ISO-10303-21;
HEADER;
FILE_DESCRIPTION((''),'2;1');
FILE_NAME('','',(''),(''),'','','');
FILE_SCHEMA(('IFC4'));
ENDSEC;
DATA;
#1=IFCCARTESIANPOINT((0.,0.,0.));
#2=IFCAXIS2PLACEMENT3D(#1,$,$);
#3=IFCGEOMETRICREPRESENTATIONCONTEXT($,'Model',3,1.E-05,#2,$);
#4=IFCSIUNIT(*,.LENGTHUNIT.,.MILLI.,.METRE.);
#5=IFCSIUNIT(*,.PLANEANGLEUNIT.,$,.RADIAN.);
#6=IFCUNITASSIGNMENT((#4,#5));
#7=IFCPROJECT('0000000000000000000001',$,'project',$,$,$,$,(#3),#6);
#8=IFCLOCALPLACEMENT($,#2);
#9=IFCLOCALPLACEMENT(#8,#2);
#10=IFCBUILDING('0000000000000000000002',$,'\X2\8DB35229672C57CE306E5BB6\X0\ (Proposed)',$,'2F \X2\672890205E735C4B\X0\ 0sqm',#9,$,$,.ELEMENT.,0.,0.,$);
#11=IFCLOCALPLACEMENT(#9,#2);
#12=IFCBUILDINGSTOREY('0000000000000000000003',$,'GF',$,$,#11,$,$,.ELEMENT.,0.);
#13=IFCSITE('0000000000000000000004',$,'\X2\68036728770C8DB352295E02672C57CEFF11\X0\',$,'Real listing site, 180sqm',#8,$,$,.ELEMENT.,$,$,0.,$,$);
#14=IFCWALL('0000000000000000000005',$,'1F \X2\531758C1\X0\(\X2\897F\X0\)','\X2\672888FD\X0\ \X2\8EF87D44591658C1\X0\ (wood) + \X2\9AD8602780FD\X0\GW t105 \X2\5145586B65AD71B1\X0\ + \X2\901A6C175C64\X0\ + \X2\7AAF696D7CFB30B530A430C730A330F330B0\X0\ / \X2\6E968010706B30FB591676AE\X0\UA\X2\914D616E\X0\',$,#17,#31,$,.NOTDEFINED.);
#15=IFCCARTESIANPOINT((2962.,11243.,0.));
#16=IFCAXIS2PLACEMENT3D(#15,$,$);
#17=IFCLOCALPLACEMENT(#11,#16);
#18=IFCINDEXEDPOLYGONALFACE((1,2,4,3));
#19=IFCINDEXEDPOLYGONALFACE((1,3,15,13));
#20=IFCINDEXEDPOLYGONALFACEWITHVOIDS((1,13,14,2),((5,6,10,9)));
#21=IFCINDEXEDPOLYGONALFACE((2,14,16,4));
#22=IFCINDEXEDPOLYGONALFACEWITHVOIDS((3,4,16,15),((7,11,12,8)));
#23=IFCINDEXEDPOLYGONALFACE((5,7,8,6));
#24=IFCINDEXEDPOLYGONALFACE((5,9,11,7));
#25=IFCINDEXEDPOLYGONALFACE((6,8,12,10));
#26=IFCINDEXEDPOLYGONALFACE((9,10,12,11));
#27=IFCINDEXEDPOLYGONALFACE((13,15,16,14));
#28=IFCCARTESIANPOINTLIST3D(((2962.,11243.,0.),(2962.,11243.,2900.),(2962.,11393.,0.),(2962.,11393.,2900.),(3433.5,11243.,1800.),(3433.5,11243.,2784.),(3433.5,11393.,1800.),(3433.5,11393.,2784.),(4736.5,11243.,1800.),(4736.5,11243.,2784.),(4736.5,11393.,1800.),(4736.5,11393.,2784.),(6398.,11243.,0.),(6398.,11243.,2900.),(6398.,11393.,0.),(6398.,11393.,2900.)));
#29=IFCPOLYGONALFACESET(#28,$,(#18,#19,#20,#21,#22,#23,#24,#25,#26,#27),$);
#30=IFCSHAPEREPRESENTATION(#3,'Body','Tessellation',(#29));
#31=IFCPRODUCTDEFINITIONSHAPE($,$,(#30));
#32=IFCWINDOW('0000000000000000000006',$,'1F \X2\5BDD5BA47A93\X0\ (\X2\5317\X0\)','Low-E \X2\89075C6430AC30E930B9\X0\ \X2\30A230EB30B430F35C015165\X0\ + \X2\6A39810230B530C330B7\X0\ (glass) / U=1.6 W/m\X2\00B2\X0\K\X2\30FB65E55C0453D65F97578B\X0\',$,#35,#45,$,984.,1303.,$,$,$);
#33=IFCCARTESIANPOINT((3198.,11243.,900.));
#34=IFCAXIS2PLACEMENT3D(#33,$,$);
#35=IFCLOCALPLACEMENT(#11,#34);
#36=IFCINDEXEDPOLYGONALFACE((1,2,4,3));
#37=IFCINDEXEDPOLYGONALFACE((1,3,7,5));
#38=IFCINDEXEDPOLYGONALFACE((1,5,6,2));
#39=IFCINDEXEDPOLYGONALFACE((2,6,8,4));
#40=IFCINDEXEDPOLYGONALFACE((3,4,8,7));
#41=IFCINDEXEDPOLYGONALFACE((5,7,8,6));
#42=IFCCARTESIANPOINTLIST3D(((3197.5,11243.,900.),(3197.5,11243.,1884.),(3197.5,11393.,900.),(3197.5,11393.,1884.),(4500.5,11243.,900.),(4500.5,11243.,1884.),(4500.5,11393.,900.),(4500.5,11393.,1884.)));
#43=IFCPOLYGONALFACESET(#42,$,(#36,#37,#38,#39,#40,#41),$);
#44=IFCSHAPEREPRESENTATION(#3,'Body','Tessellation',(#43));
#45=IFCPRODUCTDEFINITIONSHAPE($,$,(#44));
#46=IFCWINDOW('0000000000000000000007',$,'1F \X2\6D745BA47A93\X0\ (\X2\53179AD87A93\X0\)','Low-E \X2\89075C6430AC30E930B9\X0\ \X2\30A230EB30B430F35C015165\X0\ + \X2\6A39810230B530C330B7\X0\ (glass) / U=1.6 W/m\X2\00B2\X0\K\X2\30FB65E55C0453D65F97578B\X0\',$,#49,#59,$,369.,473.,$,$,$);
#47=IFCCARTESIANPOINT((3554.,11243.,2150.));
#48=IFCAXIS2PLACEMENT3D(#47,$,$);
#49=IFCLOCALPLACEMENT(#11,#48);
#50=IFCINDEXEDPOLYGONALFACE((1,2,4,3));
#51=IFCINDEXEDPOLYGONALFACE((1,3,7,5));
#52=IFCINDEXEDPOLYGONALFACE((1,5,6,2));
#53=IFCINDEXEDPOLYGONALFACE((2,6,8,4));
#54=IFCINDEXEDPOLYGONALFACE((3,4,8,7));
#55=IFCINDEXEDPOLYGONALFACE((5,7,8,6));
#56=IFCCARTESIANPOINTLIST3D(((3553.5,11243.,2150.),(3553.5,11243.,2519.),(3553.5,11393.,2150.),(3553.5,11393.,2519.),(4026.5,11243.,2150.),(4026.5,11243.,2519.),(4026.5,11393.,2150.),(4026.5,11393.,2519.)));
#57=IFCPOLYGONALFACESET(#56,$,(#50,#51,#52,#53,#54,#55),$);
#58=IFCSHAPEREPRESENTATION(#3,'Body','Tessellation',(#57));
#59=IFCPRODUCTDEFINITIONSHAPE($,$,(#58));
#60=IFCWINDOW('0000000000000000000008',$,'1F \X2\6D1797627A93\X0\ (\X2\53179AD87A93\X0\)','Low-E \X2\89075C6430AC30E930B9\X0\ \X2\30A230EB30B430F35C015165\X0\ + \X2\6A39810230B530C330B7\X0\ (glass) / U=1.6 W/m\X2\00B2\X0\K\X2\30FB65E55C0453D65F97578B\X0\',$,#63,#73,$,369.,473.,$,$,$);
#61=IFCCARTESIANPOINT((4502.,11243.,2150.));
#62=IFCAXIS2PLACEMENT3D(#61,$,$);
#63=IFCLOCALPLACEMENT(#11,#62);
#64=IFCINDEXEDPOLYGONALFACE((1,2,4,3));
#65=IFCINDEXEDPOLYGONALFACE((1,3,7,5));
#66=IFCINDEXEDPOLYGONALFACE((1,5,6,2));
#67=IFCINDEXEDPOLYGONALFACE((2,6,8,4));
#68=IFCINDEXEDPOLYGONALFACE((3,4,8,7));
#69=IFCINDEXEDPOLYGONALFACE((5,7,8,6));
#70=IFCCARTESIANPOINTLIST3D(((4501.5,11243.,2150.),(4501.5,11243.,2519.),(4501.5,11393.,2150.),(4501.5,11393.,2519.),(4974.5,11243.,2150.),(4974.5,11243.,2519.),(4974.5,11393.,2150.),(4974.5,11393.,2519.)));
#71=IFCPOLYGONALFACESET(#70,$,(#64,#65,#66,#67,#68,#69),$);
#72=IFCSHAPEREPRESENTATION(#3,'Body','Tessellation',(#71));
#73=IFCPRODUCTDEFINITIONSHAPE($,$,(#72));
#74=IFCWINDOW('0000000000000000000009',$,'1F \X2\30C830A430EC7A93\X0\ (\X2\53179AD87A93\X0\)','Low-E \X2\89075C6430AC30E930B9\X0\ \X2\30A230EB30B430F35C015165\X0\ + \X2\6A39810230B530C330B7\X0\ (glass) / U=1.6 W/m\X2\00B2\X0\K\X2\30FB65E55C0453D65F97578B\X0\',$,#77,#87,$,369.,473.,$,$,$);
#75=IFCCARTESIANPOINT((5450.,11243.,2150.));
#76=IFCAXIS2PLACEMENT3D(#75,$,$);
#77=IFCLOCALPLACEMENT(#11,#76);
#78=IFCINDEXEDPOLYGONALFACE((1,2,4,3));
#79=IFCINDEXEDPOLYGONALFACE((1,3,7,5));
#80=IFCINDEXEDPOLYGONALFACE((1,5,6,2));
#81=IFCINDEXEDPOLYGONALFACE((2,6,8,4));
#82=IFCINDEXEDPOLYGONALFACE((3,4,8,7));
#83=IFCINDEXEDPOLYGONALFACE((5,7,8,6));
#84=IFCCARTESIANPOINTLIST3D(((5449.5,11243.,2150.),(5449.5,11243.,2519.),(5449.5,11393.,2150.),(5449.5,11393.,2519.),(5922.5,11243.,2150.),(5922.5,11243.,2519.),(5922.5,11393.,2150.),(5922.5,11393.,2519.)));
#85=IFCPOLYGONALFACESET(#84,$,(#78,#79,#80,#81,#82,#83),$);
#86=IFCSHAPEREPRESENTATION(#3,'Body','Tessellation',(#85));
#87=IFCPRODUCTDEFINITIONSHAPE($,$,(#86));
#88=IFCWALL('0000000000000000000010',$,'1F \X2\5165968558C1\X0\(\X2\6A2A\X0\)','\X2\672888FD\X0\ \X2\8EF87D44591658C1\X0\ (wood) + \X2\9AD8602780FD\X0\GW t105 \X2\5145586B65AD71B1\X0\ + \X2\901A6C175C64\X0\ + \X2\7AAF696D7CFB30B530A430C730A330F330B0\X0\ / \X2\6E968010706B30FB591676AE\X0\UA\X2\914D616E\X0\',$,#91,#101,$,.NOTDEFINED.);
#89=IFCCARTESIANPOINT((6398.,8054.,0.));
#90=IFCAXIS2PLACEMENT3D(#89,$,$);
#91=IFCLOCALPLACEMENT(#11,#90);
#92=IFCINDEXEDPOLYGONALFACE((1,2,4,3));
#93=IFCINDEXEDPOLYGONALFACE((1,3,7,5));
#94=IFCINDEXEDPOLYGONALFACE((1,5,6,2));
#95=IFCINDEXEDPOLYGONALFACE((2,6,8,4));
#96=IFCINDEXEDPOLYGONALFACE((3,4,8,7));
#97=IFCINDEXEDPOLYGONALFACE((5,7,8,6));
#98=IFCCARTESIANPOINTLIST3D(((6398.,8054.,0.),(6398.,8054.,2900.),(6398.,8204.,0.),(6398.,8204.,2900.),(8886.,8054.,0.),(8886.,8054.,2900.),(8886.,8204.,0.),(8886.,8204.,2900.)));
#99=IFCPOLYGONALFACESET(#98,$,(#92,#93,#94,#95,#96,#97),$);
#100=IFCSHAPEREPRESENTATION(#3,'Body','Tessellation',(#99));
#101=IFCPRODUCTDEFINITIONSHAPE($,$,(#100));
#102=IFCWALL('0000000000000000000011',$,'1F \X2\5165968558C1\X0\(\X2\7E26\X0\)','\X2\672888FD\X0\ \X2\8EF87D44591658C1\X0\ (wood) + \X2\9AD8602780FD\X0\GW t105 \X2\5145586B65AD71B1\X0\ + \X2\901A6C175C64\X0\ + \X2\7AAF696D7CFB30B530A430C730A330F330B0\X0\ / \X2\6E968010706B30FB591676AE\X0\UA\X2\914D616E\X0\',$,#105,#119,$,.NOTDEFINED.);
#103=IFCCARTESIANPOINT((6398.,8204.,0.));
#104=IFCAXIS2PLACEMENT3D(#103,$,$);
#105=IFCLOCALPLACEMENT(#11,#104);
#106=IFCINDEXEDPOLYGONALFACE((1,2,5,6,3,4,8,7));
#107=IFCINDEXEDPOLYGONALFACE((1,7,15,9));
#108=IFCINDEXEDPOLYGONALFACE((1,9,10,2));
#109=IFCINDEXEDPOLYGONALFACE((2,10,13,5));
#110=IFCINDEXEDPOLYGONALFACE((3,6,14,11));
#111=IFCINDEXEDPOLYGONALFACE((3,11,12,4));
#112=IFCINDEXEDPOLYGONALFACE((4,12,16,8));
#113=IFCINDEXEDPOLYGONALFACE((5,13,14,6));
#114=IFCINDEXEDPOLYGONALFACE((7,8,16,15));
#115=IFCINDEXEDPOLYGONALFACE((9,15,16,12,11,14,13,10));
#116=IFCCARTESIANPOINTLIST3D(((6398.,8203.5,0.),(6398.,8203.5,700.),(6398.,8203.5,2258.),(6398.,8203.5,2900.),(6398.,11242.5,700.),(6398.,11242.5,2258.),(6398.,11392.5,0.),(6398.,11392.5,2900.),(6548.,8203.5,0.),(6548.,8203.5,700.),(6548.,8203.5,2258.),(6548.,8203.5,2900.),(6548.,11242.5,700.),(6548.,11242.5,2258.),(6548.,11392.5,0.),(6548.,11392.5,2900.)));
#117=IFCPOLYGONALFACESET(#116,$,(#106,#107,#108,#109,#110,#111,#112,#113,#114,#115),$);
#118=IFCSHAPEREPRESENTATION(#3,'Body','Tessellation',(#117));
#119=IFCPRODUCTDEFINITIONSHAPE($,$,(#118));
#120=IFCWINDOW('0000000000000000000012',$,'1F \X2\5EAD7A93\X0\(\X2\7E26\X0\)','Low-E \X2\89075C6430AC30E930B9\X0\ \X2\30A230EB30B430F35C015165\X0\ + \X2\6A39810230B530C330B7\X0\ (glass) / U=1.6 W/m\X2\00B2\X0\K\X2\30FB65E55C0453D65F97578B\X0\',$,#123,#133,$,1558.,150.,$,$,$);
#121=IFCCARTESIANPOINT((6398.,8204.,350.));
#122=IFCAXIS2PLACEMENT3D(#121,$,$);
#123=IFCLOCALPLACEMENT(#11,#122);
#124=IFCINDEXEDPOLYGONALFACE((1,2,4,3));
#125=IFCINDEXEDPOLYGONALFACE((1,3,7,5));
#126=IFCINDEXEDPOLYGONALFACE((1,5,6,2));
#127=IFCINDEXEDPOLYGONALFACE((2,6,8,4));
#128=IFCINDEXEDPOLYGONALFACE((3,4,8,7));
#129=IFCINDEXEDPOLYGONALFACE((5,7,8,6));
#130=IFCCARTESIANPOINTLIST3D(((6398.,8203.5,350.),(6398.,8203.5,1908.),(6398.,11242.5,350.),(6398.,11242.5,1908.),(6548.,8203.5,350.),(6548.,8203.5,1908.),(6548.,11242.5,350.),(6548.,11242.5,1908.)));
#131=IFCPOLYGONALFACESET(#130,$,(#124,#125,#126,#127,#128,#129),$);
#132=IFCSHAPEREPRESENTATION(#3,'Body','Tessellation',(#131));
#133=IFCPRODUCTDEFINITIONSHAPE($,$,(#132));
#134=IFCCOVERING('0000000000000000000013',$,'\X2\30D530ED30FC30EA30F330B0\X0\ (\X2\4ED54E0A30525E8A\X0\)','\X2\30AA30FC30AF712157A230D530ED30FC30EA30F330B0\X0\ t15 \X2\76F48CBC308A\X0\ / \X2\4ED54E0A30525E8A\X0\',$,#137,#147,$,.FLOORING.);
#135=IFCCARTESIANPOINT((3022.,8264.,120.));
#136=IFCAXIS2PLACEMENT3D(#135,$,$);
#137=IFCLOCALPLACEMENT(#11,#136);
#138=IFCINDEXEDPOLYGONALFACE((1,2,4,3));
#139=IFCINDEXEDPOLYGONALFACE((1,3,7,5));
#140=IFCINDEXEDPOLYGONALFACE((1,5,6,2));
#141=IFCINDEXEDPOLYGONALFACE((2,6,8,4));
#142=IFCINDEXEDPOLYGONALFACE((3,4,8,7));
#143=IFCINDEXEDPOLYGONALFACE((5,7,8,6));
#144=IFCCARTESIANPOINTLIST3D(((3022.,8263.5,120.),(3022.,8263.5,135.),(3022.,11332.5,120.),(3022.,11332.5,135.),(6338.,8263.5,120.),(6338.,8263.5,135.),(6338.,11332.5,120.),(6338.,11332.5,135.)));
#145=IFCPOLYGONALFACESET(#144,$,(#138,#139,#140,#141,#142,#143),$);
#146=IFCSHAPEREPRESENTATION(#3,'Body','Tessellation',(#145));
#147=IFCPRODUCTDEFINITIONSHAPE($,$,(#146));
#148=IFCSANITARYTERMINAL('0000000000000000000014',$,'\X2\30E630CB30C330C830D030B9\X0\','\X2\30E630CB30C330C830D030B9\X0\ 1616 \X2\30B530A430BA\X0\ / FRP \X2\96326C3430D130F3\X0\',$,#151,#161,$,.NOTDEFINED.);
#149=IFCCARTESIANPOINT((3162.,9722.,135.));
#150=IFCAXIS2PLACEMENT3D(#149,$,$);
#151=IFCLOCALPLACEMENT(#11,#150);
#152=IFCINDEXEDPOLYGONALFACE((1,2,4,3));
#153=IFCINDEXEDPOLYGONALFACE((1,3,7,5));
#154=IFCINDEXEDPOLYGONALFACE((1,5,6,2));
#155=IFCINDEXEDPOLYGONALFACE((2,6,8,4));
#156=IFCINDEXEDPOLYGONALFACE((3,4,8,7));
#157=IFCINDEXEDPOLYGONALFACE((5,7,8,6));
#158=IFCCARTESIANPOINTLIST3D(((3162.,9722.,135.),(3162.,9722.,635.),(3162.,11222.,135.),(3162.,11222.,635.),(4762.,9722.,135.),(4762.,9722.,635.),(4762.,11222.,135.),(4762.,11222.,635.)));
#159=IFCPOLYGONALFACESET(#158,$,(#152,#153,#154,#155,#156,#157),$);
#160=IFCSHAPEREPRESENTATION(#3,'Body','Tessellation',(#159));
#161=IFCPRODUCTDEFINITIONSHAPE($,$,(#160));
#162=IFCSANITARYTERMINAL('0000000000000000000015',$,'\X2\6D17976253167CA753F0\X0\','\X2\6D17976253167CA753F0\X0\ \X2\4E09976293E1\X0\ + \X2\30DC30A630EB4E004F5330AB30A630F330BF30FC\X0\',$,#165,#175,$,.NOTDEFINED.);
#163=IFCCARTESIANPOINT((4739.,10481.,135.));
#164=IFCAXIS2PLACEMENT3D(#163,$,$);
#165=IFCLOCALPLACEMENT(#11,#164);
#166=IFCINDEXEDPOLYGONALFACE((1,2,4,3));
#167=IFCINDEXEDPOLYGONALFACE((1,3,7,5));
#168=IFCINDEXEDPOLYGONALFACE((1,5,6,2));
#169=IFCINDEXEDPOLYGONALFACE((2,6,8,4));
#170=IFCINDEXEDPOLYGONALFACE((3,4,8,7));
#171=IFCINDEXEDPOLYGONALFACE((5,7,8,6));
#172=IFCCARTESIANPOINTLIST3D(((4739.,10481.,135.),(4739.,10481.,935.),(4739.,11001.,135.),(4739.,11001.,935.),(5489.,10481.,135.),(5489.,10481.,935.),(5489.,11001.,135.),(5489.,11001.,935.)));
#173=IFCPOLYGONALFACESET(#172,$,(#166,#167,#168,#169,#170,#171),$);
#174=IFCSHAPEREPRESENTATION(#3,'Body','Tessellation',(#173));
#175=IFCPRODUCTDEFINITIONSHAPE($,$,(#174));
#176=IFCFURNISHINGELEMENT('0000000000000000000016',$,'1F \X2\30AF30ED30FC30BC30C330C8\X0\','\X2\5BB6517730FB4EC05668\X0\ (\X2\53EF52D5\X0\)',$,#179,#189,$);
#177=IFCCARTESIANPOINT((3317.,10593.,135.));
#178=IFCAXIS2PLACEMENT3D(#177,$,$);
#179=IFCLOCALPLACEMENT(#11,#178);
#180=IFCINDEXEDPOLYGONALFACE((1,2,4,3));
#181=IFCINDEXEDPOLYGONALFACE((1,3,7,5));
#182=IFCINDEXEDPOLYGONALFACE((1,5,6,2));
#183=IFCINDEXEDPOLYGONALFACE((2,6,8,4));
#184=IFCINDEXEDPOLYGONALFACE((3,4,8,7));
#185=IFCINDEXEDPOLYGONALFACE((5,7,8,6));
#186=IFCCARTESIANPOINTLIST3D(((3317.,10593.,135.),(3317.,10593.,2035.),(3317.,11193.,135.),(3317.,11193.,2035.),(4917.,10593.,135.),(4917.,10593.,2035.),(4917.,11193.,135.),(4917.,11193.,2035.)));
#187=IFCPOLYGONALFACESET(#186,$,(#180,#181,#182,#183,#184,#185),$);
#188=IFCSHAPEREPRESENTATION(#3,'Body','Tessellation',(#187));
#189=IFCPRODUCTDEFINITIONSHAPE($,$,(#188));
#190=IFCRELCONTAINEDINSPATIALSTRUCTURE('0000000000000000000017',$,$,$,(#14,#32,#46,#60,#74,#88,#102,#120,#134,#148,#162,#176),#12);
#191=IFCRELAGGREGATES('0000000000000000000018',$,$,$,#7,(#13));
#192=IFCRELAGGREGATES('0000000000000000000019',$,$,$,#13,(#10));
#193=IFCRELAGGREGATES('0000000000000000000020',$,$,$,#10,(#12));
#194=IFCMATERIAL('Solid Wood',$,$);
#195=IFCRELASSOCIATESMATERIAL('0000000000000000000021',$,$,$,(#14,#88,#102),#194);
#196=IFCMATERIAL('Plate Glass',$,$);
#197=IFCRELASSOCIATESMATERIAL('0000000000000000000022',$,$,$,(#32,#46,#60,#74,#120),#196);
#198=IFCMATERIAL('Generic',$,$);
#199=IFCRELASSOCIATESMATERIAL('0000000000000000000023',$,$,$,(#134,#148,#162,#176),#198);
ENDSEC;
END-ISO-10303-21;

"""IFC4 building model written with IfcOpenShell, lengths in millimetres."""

from ifc_helpers import new_model, si_unit, frame, frame_2d, origin, place, context, project, spatial, rectangle, extrude, material, element, fill, save


model = new_model("IFC4")

# Units and contexts
model_context = context("Model", 3, precision=1e-05, world=origin())
ifc_project = project(units=[si_unit("LENGTHUNIT", "METRE", prefix="MILLI"), si_unit("PLANEANGLEUNIT", "RADIAN")], contexts=[model_context])

# Site, building, storey
site_placement = place(None, origin())
site = spatial("IfcSite", under=ifc_project, at=site_placement, Name="栃木県足利市本城１", ObjectType="Real listing site, 180sqm", CompositionType="ELEMENT", RefElevation=0.0)
building_placement = place(site_placement, origin())
building = spatial("IfcBuilding", under=site, at=building_placement, Name="足利本城の家 (Proposed)", ObjectType="2F 木造平屋 0sqm", CompositionType="ELEMENT", ElevationOfRefHeight=0.0, ElevationOfTerrain=0.0)
storey_placement = place(building_placement, origin())
storey = spatial("IfcBuildingStorey", under=building, at=storey_placement, Name="GF", CompositionType="ELEMENT", Elevation=0.0)

# Shared definitions
ifc_material_1 = material(Name="Solid Wood")

# Wall, openings, windows
wall_1_placement = place(storey_placement, frame((2962.0, 11243.0, 0.0)))
wall_1 = element("IfcWall", 1, at=wall_1_placement, inside=storey, material=ifc_material_1, Name="1F 北壁(西)", Description="木製 軸組外壁 (wood) + 高性能GW t105 充填断熱 + 通気層 + 窯業系サイディング / 準耐火・外皮UA配慮", PredefinedType="NOTDEFINED", context=model_context, shape_type="SweptSolid", body=[
    extrude(rectangle(XDim=3436.0, YDim=150.0, at=frame_2d((1718.0, 75.0))), frame((2962.0, 11243.0, 0.0)), (0.0, 0.0, 1.0), 2900.0),
])
opening_1_placement = place(storey_placement, frame((3198.0, 11243.0, 900.0)))
opening_1 = element("IfcOpeningElement", 2, at=opening_1_placement, cuts=wall_1, PredefinedType="NOTDEFINED", context=model_context, shape_type="SweptSolid", body=[
    extrude(rectangle(XDim=1303.0, YDim=150.0, at=frame_2d((651.0, 75.0))), frame((3198.0, 11243.0, 900.0)), (0.0, 0.0, 1.0), 984.0),
])
opening_2_placement = place(storey_placement, frame((3554.0, 11243.0, 2150.0)))
opening_2 = element("IfcOpeningElement", 3, at=opening_2_placement, cuts=wall_1, PredefinedType="NOTDEFINED", context=model_context, shape_type="SweptSolid", body=[
    extrude(rectangle(XDim=473.0, YDim=150.0, at=frame_2d((236.0, 75.0))), frame((3554.0, 11243.0, 2150.0)), (0.0, 0.0, 1.0), 369.0),
])
opening_3_placement = place(storey_placement, frame((4502.0, 11243.0, 2150.0)))
opening_3 = element("IfcOpeningElement", 4, at=opening_3_placement, cuts=wall_1, PredefinedType="NOTDEFINED", context=model_context, shape_type="SweptSolid", body=[
    extrude(rectangle(XDim=473.0, YDim=150.0, at=frame_2d((236.0, 75.0))), frame((4502.0, 11243.0, 2150.0)), (0.0, 0.0, 1.0), 369.0),
])
opening_4_placement = place(storey_placement, frame((5450.0, 11243.0, 2150.0)))
opening_4 = element("IfcOpeningElement", 5, at=opening_4_placement, cuts=wall_1, PredefinedType="NOTDEFINED", context=model_context, shape_type="SweptSolid", body=[
    extrude(rectangle(XDim=473.0, YDim=150.0, at=frame_2d((236.0, 75.0))), frame((5450.0, 11243.0, 2150.0)), (0.0, 0.0, 1.0), 369.0),
])
ifc_material_2 = material(Name="Plate Glass")
window_1_placement = place(storey_placement, frame((3198.0, 11243.0, 900.0)))
window_1 = element("IfcWindow", 6, at=window_1_placement, inside=storey, material=ifc_material_2, Name="1F 寝室窓 (北)", Description="Low-E 複層ガラス アルゴン封入 + 樹脂サッシ (glass) / U=1.6 W/m²K・日射取得型", OverallHeight=984.0, OverallWidth=1303.0, context=model_context, shape_type="SweptSolid", body=[
    extrude(rectangle(XDim=1303.0, YDim=150.0, at=frame_2d((651.0, 75.0))), frame((3198.0, 11243.0, 900.0)), (0.0, 0.0, 1.0), 984.0),
])
fill(opening_1, window_1)
window_2_placement = place(storey_placement, frame((3554.0, 11243.0, 2150.0)))
window_2 = element("IfcWindow", 7, at=window_2_placement, inside=storey, material=ifc_material_2, Name="1F 浴室窓 (北高窓)", Description="Low-E 複層ガラス アルゴン封入 + 樹脂サッシ (glass) / U=1.6 W/m²K・日射取得型", OverallHeight=369.0, OverallWidth=473.0, context=model_context, shape_type="SweptSolid", body=[
    extrude(rectangle(XDim=473.0, YDim=150.0, at=frame_2d((236.0, 75.0))), frame((3554.0, 11243.0, 2150.0)), (0.0, 0.0, 1.0), 369.0),
])
fill(opening_2, window_2)
window_3_placement = place(storey_placement, frame((4502.0, 11243.0, 2150.0)))
window_3 = element("IfcWindow", 8, at=window_3_placement, inside=storey, material=ifc_material_2, Name="1F 洗面窓 (北高窓)", Description="Low-E 複層ガラス アルゴン封入 + 樹脂サッシ (glass) / U=1.6 W/m²K・日射取得型", OverallHeight=369.0, OverallWidth=473.0, context=model_context, shape_type="SweptSolid", body=[
    extrude(rectangle(XDim=473.0, YDim=150.0, at=frame_2d((236.0, 75.0))), frame((4502.0, 11243.0, 2150.0)), (0.0, 0.0, 1.0), 369.0),
])
fill(opening_3, window_3)
window_4_placement = place(storey_placement, frame((5450.0, 11243.0, 2150.0)))
window_4 = element("IfcWindow", 9, at=window_4_placement, inside=storey, material=ifc_material_2, Name="1F トイレ窓 (北高窓)", Description="Low-E 複層ガラス アルゴン封入 + 樹脂サッシ (glass) / U=1.6 W/m²K・日射取得型", OverallHeight=369.0, OverallWidth=473.0, context=model_context, shape_type="SweptSolid", body=[
    extrude(rectangle(XDim=473.0, YDim=150.0, at=frame_2d((236.0, 75.0))), frame((5450.0, 11243.0, 2150.0)), (0.0, 0.0, 1.0), 369.0),
])
fill(opening_4, window_4)

# Wall
wall_2_placement = place(storey_placement, frame((6398.0, 8054.0, 0.0)))
element("IfcWall", 10, at=wall_2_placement, inside=storey, material=ifc_material_1, Name="1F 入隅壁(横)", Description="木製 軸組外壁 (wood) + 高性能GW t105 充填断熱 + 通気層 + 窯業系サイディング / 準耐火・外皮UA配慮", PredefinedType="NOTDEFINED", context=model_context, shape_type="SweptSolid", body=[
    extrude(rectangle(XDim=2488.0, YDim=150.0, at=frame_2d((1244.0, 75.0))), frame((6398.0, 8054.0, 0.0)), (0.0, 0.0, 1.0), 2900.0),
])

# Wall, opening, window
wall_3_placement = place(storey_placement, frame((6398.0, 8204.0, 0.0)))
wall_3 = element("IfcWall", 11, at=wall_3_placement, inside=storey, material=ifc_material_1, Name="1F 入隅壁(縦)", Description="木製 軸組外壁 (wood) + 高性能GW t105 充填断熱 + 通気層 + 窯業系サイディング / 準耐火・外皮UA配慮", PredefinedType="NOTDEFINED", context=model_context, shape_type="SweptSolid", body=[
    extrude(rectangle(XDim=150.0, YDim=3189.0, at=frame_2d((75.0, 1594.0))), frame((6398.0, 8204.0, 0.0)), (0.0, 0.0, 1.0), 2900.0),
])
opening_5_placement = place(storey_placement, frame((6398.0, 8204.0, 350.0)))
opening_5 = element("IfcOpeningElement", 12, at=opening_5_placement, cuts=wall_3, PredefinedType="NOTDEFINED", context=model_context, shape_type="SweptSolid", body=[
    extrude(rectangle(XDim=150.0, YDim=3039.0, at=frame_2d((75.0, 1519.0))), frame((6398.0, 8204.0, 350.0)), (0.0, 0.0, 1.0), 1558.0),
])
window_5_placement = place(storey_placement, frame((6398.0, 8204.0, 350.0)))
window_5 = element("IfcWindow", 13, at=window_5_placement, inside=storey, material=ifc_material_2, Name="1F 庭窓(縦)", Description="Low-E 複層ガラス アルゴン封入 + 樹脂サッシ (glass) / U=1.6 W/m²K・日射取得型", OverallHeight=1558.0, OverallWidth=150.0, context=model_context, shape_type="SweptSolid", body=[
    extrude(rectangle(XDim=150.0, YDim=3039.0, at=frame_2d((75.0, 1519.0))), frame((6398.0, 8204.0, 350.0)), (0.0, 0.0, 1.0), 1558.0),
])
fill(opening_5, window_5)

# Covering
ifc_material_3 = material(Name="Generic")
covering_placement = place(storey_placement, frame((3022.0, 8264.0, 120.0)))
element("IfcCovering", 14, at=covering_placement, inside=storey, material=ifc_material_3, Name="フローリング (仕上げ床)", Description="オーク無垢フローリング t15 直貼り / 仕上げ床", PredefinedType="FLOORING", context=model_context, shape_type="SweptSolid", body=[
    extrude(rectangle(XDim=3316.0, YDim=3069.0, at=frame_2d((1658.0, 1534.0))), frame((3022.0, 8264.0, 120.0)), (0.0, 0.0, 1.0), 15.0),
])

# Sanitary terminals
sanitary_terminal_1_placement = place(storey_placement, frame((3162.0, 9722.0, 135.0)))
element("IfcSanitaryTerminal", 15, at=sanitary_terminal_1_placement, inside=storey, material=ifc_material_3, Name="ユニットバス", Description="ユニットバス 1616 サイズ / FRP 防水パン", PredefinedType="NOTDEFINED", context=model_context, shape_type="SweptSolid", body=[
    extrude(rectangle(XDim=1600.0, YDim=1500.0, at=frame_2d((800.0, 750.0))), frame((3162.0, 9722.0, 135.0)), (0.0, 0.0, 1.0), 500.0),
])
sanitary_terminal_2_placement = place(storey_placement, frame((4739.0, 10481.0, 135.0)))
element("IfcSanitaryTerminal", 16, at=sanitary_terminal_2_placement, inside=storey, material=ifc_material_3, Name="洗面化粧台", Description="洗面化粧台 三面鏡 + ボウル一体カウンター", PredefinedType="NOTDEFINED", context=model_context, shape_type="SweptSolid", body=[
    extrude(rectangle(XDim=750.0, YDim=520.0, at=frame_2d((375.0, 260.0))), frame((4739.0, 10481.0, 135.0)), (0.0, 0.0, 1.0), 800.0),
])

# Furnishing element
furnishing_1_placement = place(storey_placement, frame((3317.0, 10593.0, 135.0)))
element("IfcFurnishingElement", 17, at=furnishing_1_placement, inside=storey, material=ifc_material_3, Name="1F クローゼット", Description="家具・什器 (可動)", context=model_context, shape_type="SweptSolid", body=[
    extrude(rectangle(XDim=1600.0, YDim=600.0, at=frame_2d((800.0, 300.0))), frame((3317.0, 10593.0, 135.0)), (0.0, 0.0, 1.0), 1900.0),
])

save(model, "model.ifc")
